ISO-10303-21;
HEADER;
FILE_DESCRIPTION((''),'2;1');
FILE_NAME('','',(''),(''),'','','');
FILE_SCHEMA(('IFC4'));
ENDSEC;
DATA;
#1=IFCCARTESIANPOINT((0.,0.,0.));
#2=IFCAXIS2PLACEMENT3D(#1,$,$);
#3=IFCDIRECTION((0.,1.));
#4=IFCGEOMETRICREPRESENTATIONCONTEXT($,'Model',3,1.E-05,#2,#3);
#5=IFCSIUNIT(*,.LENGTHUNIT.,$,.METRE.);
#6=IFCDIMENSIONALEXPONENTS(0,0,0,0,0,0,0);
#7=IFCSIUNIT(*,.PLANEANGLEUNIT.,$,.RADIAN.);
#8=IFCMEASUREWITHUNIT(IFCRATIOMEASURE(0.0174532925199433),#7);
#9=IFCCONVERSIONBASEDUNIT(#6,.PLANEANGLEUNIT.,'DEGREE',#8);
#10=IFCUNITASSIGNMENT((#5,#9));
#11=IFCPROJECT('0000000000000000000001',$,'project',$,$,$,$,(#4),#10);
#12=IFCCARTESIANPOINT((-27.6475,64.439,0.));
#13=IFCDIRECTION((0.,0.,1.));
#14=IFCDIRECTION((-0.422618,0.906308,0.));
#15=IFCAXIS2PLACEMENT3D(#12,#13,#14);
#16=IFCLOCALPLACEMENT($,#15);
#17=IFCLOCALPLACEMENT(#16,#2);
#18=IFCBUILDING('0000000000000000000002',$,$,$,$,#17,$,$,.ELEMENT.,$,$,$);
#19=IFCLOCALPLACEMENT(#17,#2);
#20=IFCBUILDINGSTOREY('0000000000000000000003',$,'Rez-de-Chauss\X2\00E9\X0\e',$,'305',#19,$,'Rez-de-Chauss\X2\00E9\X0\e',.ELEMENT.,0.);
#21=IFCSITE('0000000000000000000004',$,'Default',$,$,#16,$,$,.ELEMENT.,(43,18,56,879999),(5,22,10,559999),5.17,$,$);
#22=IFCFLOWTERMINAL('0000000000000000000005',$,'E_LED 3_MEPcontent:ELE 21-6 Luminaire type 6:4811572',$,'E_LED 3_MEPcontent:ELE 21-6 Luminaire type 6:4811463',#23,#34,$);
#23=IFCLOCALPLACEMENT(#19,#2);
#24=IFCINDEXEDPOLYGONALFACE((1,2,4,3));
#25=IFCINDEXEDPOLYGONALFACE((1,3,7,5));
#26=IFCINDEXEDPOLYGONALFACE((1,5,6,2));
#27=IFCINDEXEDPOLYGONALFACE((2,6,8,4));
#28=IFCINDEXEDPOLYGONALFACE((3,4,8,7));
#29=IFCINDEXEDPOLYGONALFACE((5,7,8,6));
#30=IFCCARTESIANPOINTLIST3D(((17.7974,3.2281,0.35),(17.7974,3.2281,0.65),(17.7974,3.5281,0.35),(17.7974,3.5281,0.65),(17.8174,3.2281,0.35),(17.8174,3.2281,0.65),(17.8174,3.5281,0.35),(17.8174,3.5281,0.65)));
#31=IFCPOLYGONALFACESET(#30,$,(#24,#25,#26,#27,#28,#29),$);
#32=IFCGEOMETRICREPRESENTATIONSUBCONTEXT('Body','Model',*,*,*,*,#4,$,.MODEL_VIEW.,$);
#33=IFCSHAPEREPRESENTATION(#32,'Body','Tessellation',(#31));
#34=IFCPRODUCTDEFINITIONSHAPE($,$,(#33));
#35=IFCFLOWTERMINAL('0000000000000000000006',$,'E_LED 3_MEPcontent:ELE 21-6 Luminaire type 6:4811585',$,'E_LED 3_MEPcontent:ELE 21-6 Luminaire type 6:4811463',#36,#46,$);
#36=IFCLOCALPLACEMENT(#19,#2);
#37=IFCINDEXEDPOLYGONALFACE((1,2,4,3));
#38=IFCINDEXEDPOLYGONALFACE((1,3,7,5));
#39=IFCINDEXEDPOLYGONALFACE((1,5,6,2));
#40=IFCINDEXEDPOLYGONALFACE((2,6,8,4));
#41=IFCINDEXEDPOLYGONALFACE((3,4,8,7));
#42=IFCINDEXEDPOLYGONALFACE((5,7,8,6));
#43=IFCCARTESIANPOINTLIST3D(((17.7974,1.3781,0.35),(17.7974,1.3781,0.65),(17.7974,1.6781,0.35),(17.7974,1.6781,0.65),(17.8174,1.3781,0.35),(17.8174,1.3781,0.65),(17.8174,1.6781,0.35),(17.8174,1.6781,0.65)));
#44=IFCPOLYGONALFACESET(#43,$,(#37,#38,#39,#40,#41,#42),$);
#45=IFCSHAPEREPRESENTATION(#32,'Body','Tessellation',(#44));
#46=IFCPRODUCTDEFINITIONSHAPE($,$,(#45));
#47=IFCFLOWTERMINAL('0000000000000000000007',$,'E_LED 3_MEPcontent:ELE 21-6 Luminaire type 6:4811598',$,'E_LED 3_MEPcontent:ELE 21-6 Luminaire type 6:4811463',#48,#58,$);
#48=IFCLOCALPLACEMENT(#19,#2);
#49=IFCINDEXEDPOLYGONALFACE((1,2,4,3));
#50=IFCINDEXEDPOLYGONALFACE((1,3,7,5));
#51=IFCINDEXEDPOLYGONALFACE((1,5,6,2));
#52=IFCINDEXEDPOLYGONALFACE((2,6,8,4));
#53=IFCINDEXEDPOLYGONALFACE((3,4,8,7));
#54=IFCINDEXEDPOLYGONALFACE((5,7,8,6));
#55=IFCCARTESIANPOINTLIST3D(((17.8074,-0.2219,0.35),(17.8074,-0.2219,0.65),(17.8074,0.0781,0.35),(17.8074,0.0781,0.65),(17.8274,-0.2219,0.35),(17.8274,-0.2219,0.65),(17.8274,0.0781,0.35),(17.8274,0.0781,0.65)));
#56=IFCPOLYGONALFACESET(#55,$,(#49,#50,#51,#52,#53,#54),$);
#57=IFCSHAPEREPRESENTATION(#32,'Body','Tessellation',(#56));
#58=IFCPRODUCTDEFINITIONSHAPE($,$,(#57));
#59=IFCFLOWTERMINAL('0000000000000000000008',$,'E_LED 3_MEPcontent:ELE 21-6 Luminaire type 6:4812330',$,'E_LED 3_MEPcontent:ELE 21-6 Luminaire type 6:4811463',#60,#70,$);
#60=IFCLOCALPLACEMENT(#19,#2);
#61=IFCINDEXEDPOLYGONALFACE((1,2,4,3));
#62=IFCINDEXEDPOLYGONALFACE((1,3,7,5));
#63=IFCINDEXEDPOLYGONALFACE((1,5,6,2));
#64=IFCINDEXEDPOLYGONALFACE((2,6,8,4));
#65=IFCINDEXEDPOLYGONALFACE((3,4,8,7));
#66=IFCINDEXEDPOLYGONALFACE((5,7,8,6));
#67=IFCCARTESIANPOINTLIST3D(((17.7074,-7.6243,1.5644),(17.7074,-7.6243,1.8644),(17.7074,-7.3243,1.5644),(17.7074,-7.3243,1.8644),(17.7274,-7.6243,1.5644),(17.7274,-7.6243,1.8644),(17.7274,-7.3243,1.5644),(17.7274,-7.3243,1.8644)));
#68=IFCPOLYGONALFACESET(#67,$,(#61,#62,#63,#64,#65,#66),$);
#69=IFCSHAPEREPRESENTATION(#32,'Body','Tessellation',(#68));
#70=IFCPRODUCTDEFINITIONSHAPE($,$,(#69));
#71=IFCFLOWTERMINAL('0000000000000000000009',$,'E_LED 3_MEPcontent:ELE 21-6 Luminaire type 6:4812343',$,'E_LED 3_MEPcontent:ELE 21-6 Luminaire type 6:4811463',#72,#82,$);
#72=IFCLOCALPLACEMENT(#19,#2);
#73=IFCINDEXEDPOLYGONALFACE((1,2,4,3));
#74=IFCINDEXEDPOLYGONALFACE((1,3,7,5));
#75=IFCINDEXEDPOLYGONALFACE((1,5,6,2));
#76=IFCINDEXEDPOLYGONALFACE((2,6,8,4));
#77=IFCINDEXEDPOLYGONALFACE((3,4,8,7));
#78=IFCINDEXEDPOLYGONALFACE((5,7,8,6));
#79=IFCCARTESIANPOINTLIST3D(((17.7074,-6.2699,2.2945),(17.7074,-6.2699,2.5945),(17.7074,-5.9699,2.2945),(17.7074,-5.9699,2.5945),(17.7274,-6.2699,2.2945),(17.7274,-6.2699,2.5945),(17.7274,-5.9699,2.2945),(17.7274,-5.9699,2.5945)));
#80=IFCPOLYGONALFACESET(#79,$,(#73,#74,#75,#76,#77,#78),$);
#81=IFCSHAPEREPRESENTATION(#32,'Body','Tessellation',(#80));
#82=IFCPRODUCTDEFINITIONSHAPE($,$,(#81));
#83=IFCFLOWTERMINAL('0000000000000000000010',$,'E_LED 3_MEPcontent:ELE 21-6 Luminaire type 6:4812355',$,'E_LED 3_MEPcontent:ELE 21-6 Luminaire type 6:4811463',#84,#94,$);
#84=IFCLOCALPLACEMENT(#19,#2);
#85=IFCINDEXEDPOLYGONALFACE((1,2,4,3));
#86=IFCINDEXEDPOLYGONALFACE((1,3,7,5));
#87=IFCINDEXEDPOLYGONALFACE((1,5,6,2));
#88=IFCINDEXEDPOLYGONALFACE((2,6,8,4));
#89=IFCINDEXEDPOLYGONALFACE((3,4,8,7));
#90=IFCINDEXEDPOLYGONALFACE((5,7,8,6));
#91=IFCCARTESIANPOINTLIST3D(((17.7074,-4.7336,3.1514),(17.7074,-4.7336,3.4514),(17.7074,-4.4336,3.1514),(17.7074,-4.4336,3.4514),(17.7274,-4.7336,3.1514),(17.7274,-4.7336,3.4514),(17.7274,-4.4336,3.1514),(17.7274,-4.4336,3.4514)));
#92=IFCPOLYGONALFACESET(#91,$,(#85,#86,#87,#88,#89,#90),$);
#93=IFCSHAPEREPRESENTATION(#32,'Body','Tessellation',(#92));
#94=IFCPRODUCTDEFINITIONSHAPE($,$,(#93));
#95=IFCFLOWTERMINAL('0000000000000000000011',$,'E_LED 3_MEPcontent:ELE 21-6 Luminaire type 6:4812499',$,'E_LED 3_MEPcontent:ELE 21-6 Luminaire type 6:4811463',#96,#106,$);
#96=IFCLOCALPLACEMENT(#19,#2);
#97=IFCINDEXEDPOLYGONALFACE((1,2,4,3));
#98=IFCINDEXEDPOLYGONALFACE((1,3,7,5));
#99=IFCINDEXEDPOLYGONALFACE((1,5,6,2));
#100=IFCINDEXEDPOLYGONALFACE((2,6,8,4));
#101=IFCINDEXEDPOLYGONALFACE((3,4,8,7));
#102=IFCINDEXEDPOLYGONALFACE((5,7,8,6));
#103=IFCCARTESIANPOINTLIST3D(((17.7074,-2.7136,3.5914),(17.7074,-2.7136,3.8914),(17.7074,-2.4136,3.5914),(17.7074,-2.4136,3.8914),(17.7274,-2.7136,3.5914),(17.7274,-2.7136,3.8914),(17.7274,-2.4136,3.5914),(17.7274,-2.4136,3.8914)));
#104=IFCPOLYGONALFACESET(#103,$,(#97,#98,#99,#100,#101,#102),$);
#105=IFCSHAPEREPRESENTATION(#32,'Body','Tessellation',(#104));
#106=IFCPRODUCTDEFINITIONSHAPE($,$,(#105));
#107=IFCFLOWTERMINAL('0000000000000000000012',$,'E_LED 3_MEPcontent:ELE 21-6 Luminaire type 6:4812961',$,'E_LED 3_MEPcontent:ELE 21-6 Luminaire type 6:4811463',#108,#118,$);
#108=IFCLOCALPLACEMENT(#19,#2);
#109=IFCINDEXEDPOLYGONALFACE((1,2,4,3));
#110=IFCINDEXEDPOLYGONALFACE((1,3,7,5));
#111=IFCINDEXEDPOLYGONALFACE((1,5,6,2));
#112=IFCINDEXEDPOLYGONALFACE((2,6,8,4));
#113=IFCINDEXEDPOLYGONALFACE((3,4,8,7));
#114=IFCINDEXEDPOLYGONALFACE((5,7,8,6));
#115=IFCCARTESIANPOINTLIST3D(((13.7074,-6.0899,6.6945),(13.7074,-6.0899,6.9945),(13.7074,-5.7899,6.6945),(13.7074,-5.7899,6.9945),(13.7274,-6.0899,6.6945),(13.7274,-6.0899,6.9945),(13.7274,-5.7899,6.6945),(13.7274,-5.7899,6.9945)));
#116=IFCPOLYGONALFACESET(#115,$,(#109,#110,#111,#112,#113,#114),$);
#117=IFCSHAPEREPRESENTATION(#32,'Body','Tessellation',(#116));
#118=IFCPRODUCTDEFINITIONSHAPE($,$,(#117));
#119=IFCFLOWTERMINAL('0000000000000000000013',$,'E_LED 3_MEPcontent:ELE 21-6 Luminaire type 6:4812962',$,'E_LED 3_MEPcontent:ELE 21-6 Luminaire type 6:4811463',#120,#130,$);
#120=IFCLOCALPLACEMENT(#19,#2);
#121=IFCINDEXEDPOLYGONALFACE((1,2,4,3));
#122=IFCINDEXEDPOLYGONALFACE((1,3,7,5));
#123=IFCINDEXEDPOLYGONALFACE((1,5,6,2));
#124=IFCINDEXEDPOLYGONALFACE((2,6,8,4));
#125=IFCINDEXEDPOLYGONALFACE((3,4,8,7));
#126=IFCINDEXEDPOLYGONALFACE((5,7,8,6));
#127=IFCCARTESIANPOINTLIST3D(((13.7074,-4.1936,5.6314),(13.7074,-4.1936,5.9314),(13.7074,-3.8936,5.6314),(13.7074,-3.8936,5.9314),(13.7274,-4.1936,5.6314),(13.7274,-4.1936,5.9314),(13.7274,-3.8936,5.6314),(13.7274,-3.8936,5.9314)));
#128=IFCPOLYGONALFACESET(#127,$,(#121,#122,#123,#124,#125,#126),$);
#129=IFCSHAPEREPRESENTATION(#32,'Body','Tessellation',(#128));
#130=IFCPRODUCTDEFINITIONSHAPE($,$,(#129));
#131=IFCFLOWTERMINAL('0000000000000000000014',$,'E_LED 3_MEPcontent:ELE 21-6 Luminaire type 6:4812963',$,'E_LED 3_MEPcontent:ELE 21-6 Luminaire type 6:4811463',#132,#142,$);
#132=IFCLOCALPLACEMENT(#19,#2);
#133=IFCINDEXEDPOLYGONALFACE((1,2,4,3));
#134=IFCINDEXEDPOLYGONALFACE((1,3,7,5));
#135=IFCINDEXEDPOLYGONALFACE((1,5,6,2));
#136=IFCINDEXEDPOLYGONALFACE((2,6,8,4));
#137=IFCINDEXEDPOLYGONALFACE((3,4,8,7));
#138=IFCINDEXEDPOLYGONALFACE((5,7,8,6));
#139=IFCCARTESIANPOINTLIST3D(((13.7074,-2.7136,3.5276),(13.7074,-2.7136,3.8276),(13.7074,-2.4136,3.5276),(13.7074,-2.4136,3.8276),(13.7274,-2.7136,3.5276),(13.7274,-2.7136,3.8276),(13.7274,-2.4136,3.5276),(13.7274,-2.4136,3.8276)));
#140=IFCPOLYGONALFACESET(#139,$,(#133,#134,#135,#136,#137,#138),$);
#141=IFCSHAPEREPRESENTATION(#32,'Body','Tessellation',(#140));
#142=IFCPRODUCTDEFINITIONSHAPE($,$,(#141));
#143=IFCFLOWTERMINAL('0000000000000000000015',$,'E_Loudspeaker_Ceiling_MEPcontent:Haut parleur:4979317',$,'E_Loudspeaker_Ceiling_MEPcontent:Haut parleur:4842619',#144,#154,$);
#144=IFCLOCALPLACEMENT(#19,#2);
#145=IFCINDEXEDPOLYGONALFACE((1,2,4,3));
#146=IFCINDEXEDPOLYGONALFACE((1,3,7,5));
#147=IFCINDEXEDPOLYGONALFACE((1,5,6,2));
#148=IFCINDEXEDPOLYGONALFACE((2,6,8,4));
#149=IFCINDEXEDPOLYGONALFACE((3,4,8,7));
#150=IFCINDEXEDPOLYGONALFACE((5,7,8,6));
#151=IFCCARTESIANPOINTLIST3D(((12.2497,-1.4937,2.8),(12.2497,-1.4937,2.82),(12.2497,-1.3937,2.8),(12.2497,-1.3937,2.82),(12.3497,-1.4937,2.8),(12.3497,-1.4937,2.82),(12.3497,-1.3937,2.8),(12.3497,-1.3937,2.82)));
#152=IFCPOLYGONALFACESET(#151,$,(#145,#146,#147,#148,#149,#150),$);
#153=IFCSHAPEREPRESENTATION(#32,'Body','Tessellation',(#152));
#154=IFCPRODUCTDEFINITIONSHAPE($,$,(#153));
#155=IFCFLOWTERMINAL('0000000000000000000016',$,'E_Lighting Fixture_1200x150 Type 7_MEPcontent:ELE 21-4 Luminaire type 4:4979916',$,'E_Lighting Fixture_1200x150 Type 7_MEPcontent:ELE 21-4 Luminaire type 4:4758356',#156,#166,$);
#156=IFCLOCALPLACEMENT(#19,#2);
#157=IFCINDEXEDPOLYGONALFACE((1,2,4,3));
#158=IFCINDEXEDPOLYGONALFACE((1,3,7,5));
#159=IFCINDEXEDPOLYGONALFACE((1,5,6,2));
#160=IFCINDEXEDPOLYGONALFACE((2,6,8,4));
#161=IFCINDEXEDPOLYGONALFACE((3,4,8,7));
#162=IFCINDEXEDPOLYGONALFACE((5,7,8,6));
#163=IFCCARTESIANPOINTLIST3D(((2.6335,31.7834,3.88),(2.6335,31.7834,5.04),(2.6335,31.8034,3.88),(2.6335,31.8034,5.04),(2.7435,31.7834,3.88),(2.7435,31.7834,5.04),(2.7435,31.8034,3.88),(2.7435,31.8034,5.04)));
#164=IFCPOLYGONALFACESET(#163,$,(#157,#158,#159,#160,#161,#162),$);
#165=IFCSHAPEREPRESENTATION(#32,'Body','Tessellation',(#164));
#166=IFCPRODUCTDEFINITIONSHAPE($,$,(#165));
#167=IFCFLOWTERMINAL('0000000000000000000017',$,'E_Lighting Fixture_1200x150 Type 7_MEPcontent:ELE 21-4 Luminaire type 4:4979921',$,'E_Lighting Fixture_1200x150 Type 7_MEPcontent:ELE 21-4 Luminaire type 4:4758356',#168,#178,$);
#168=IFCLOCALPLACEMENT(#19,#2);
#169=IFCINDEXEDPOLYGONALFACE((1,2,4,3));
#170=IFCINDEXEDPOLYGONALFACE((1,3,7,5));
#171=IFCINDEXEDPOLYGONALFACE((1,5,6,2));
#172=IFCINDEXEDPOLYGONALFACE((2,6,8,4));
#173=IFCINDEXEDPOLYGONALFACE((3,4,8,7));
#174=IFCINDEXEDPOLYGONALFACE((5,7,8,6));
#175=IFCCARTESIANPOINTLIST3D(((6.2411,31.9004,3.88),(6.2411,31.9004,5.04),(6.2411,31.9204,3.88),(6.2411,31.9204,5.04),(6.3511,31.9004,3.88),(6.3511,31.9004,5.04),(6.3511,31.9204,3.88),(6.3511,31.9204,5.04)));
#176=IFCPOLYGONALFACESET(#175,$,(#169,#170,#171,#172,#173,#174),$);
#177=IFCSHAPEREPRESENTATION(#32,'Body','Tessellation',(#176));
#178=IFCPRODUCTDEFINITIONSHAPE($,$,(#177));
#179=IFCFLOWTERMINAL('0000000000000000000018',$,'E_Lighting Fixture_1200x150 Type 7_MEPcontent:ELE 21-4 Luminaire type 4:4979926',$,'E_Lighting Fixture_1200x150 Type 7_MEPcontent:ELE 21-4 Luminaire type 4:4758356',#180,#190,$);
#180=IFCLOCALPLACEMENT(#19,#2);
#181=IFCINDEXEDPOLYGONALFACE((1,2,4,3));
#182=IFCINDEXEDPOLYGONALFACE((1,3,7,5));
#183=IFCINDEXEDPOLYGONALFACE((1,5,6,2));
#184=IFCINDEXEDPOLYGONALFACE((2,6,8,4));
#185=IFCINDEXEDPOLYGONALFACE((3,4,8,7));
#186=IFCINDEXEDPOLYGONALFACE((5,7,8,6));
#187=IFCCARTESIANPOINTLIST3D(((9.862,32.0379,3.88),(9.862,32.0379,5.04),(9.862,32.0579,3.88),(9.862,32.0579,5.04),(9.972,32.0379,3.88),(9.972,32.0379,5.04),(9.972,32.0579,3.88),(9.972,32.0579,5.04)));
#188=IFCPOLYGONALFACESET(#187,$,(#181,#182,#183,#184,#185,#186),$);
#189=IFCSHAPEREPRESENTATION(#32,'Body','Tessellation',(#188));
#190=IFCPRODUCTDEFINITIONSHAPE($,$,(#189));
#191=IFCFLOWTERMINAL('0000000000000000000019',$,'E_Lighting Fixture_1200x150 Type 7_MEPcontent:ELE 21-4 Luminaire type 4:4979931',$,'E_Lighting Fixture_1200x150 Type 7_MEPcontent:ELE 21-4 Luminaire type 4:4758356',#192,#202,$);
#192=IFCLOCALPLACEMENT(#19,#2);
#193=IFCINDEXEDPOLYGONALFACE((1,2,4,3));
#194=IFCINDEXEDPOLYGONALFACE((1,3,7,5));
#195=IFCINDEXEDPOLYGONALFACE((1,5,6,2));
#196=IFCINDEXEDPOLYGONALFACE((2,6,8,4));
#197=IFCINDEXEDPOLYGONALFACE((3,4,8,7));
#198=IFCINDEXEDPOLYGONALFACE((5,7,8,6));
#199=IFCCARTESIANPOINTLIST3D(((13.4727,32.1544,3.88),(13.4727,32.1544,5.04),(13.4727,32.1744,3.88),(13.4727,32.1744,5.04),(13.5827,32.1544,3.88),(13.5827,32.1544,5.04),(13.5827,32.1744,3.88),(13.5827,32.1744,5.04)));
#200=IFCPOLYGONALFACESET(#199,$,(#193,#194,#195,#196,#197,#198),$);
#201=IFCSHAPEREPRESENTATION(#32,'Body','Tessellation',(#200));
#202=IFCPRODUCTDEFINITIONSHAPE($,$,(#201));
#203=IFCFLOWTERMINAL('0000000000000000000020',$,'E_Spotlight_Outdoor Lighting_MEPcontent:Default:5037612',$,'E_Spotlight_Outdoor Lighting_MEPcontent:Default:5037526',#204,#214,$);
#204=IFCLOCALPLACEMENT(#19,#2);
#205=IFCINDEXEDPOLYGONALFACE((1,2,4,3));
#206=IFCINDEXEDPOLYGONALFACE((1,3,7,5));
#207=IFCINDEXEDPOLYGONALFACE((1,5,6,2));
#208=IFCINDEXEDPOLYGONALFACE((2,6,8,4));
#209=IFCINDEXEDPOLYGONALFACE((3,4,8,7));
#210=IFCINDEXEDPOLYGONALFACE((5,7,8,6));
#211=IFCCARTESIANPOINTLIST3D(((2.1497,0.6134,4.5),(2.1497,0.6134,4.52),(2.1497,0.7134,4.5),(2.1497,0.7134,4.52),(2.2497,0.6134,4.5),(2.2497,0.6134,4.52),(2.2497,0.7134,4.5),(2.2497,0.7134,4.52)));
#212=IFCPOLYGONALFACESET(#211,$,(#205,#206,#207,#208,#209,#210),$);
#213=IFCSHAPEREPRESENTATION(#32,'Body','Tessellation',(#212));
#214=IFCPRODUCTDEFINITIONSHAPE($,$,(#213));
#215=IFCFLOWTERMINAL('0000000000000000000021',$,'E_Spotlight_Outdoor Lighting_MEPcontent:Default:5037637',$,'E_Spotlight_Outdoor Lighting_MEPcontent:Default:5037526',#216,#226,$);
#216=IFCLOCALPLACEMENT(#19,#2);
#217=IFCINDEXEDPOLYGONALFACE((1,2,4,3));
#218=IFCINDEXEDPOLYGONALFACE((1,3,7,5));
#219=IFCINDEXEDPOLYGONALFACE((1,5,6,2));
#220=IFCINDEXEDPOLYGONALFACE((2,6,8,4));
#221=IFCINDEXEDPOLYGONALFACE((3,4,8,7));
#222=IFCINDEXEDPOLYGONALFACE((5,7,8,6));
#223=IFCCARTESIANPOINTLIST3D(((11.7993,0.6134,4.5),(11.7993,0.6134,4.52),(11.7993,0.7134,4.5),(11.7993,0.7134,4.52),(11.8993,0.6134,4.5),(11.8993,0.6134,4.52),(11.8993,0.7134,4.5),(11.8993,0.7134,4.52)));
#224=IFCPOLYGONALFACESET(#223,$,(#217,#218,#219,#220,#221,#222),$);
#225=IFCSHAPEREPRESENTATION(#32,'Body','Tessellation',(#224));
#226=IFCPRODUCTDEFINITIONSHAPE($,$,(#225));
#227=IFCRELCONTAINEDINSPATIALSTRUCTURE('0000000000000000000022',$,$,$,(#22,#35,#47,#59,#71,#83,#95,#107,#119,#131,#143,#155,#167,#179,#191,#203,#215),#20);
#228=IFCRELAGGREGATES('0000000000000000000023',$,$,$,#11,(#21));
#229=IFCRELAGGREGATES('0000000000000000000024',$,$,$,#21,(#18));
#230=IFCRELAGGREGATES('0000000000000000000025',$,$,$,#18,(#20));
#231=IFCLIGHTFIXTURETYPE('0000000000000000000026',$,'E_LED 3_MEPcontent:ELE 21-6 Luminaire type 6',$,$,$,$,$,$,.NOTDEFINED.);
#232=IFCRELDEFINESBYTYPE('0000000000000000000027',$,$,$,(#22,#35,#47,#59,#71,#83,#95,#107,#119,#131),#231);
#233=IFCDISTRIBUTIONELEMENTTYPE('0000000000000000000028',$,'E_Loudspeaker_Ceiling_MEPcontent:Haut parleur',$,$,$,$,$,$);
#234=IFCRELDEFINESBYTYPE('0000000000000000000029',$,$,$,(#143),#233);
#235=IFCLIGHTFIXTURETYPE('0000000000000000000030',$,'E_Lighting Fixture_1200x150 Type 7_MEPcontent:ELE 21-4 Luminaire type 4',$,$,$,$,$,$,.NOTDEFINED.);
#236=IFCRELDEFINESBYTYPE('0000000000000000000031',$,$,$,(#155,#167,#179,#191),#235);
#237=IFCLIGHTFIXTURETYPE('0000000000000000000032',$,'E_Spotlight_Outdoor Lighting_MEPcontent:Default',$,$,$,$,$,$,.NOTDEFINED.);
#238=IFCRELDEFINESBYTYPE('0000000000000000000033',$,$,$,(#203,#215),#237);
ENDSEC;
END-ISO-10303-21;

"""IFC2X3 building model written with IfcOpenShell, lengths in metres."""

from ifc_helpers import new_model, entity, si_unit, converted_unit, direction, frame, frame_2d, origin, origin_2d_with_axis, place, context, subcontext, project, spatial, rectangle, extrude, source, transform, mapped, type_object, type_shapes, element, save


model = new_model("IFC2X3")

# Units and contexts
model_context = context("Model", 3, precision=1e-05, world=origin(), true_north=direction((0.0, 1.0)))
body_context = subcontext(model_context, "Body", "Model", "MODEL_VIEW")
ifc_project = project(units=[si_unit("LENGTHUNIT", "METRE"), converted_unit("PLANEANGLEUNIT", "DEGREE", entity("IfcRatioMeasure", 0.0174532925199433), si_unit("PLANEANGLEUNIT", "RADIAN"), dimensions=[0, 0, 0, 0, 0, 0, 0])], contexts=[model_context])

# Site, building, storey
site_placement = place(None, frame((-27.6475, 64.439, 0.0), z_axis=(0.0, 0.0, 1.0), x_axis=(-0.422618, 0.906308, 0.0)))
site = spatial("IfcSite", under=ifc_project, at=site_placement, Name="Default", CompositionType="ELEMENT", RefLatitude=(43, 18, 56, 879999), RefLongitude=(5, 22, 10, 559999), RefElevation=5.17)
building_placement = place(site_placement, origin())
building = spatial("IfcBuilding", under=site, at=building_placement, CompositionType="ELEMENT")
storey_placement = place(building_placement, origin())
storey = spatial("IfcBuildingStorey", under=building, at=storey_placement, Name="Rez-de-Chaussée", ObjectType="305", LongName="Rez-de-Chaussée", CompositionType="ELEMENT", Elevation=0.0)

# Flow terminals
light_fixture_type_1 = type_object("IfcLightFixtureType", Name="E_LED 3_MEPcontent:ELE 21-6 Luminaire type 6", PredefinedType="NOTDEFINED")
shared_shape_1 = source(origin(), body_context, "Body", "SweptSolid", [
    extrude(rectangle(XDim=0.02, YDim=0.3, at=origin_2d_with_axis()), frame((0.0, 0.01, -0.15), z_axis=(0.0, 0.0, 1.0), x_axis=(0.0, -1.0, 0.0)), (0.0, 0.0, 1.0), 0.3),
])
type_shapes(light_fixture_type_1, [shared_shape_1])
for number, where, z_axis, x_axis, name in (
    (1, (17.7974, 3.3781, 0.5), (0.0, 0.0, 1.0), (0.0, -1.0, 0.0), "E_LED 3_MEPcontent:ELE 21-6 Luminaire type 6:4811572"),
    (2, (17.7974, 1.5281, 0.5), (0.0, 0.0, 1.0), (0.0, -1.0, 0.0), "E_LED 3_MEPcontent:ELE 21-6 Luminaire type 6:4811585"),
    (3, (17.8074, -0.0719, 0.5), (0.0, 0.0, 1.0), (0.0, -1.0, 0.0), "E_LED 3_MEPcontent:ELE 21-6 Luminaire type 6:4811598"),
    (4, (17.7074, -7.4743, 1.7144), (0.0, 0.0, 1.0), (0.0, -1.0, 0.0), "E_LED 3_MEPcontent:ELE 21-6 Luminaire type 6:4812330"),
    (5, (17.7074, -6.1199, 2.4445), (0.0, 0.0, 1.0), (0.0, -1.0, 0.0), "E_LED 3_MEPcontent:ELE 21-6 Luminaire type 6:4812343"),
    (6, (17.7074, -4.5836, 3.3014), (0.0, 0.0, 1.0), (0.0, -1.0, 0.0), "E_LED 3_MEPcontent:ELE 21-6 Luminaire type 6:4812355"),
    (7, (17.7074, -2.5636, 3.7414), (0.0, 0.0, 1.0), (0.0, -1.0, 0.0), "E_LED 3_MEPcontent:ELE 21-6 Luminaire type 6:4812499"),
    (8, (13.7074, -5.9399, 6.8445), (0.0, 0.0, 1.0), (0.0, -1.0, 0.0), "E_LED 3_MEPcontent:ELE 21-6 Luminaire type 6:4812961"),
    (9, (13.7074, -4.0436, 5.7814), (0.0, 0.0, 1.0), (0.0, -1.0, 0.0), "E_LED 3_MEPcontent:ELE 21-6 Luminaire type 6:4812962"),
    (10, (13.7074, -2.5636, 3.6776), (0.0, 0.0, 1.0), (0.0, -1.0, 0.0), "E_LED 3_MEPcontent:ELE 21-6 Luminaire type 6:4812963"),
):
    element("IfcFlowTerminal", number, at=place(storey_placement, frame(where, z_axis=z_axis, x_axis=x_axis)), inside=storey, type_object=light_fixture_type_1, Name=name, ObjectType="E_LED 3_MEPcontent:ELE 21-6 Luminaire type 6:4811463", context=body_context, shape_type="MappedRepresentation", body=[
        mapped(shared_shape_1, transform((0.0, 0.0, 0.0), scale=1.0)),
    ])
distribution_element_type = type_object("IfcDistributionElementType", Name="E_Loudspeaker_Ceiling_MEPcontent:Haut parleur")
shared_shape_2 = source(origin(), body_context, "Body", "SweptSolid", [
    extrude(rectangle(XDim=0.1, YDim=0.1, at=origin_2d_with_axis()), frame((0.0, 0.0, 0.0), z_axis=(0.0, 0.0, 1.0), x_axis=(0.0, -1.0, 0.0)), (0.0, 0.0, 1.0), 0.02),
])
type_shapes(distribution_element_type, [shared_shape_2])
flow_terminal_placement = place(storey_placement, frame((12.2997, -1.4437, 2.8)))
element("IfcFlowTerminal", 11, at=flow_terminal_placement, inside=storey, type_object=distribution_element_type, Name="E_Loudspeaker_Ceiling_MEPcontent:Haut parleur:4979317", ObjectType="E_Loudspeaker_Ceiling_MEPcontent:Haut parleur:4842619", context=body_context, shape_type="MappedRepresentation", body=[
    mapped(shared_shape_2, transform((0.0, 0.0, 0.0), scale=1.0)),
])
light_fixture_type_2 = type_object("IfcLightFixtureType", Name="E_Lighting Fixture_1200x150 Type 7_MEPcontent:ELE 21-4 Luminaire type 4", PredefinedType="NOTDEFINED")
shared_shape_3 = source(origin(), body_context, "Body", "SweptSolid", [
    extrude(rectangle(XDim=0.02, YDim=0.11, at=frame_2d((0.0, 0.0), x_axis=(1.0, 0.0))), frame((0.01, 0.0, -0.58), z_axis=(0.0, 0.0, 1.0), x_axis=(-1.0, 0.0, 0.0)), (0.0, 0.0, 1.0), 1.16),
])
type_shapes(light_fixture_type_2, [shared_shape_3])
for number, where, z_axis, x_axis, name in (
    (12, (2.6885, 31.8034, 4.46), (0.0, 0.0, 1.0), (0.0, -1.0, 0.0), "E_Lighting Fixture_1200x150 Type 7_MEPcontent:ELE 21-4 Luminaire type 4:4979916"),
    (13, (6.2961, 31.9204, 4.46), (0.0, 0.0, 1.0), (0.0, -1.0, 0.0), "E_Lighting Fixture_1200x150 Type 7_MEPcontent:ELE 21-4 Luminaire type 4:4979921"),
    (14, (9.917, 32.0579, 4.46), (0.0, 0.0, 1.0), (0.0, -1.0, 0.0), "E_Lighting Fixture_1200x150 Type 7_MEPcontent:ELE 21-4 Luminaire type 4:4979926"),
    (15, (13.5277, 32.1744, 4.46), (0.0, 0.0, 1.0), (0.0, -1.0, 0.0), "E_Lighting Fixture_1200x150 Type 7_MEPcontent:ELE 21-4 Luminaire type 4:4979931"),
):
    element("IfcFlowTerminal", number, at=place(storey_placement, frame(where, z_axis=z_axis, x_axis=x_axis)), inside=storey, type_object=light_fixture_type_2, Name=name, ObjectType="E_Lighting Fixture_1200x150 Type 7_MEPcontent:ELE 21-4 Luminaire type 4:4758356", context=body_context, shape_type="MappedRepresentation", body=[
        mapped(shared_shape_3, transform((0.0, 0.0, 0.0), scale=1.0)),
    ])
light_fixture_type_3 = type_object("IfcLightFixtureType", Name="E_Spotlight_Outdoor Lighting_MEPcontent:Default", PredefinedType="NOTDEFINED")
shared_shape_4 = source(origin(), body_context, "Body", "SweptSolid", [
    extrude(rectangle(XDim=0.1, YDim=0.1, at=origin_2d_with_axis()), frame((0.0, 0.0, 0.0), z_axis=(0.0, 0.0, 1.0), x_axis=(0.0, -1.0, 0.0)), (0.0, 0.0, 1.0), 0.02),
])
type_shapes(light_fixture_type_3, [shared_shape_4])
for number, where, name in (
    (16, (2.1997, 0.6634, 4.5), "E_Spotlight_Outdoor Lighting_MEPcontent:Default:5037612"),
    (17, (11.8493, 0.6634, 4.5), "E_Spotlight_Outdoor Lighting_MEPcontent:Default:5037637"),
):
    element("IfcFlowTerminal", number, at=place(storey_placement, frame(where)), inside=storey, type_object=light_fixture_type_3, Name=name, ObjectType="E_Spotlight_Outdoor Lighting_MEPcontent:Default:5037526", context=body_context, shape_type="MappedRepresentation", body=[
        mapped(shared_shape_4, transform((0.0, 0.0, 0.0), scale=1.0)),
    ])

save(model, "model.ifc")
